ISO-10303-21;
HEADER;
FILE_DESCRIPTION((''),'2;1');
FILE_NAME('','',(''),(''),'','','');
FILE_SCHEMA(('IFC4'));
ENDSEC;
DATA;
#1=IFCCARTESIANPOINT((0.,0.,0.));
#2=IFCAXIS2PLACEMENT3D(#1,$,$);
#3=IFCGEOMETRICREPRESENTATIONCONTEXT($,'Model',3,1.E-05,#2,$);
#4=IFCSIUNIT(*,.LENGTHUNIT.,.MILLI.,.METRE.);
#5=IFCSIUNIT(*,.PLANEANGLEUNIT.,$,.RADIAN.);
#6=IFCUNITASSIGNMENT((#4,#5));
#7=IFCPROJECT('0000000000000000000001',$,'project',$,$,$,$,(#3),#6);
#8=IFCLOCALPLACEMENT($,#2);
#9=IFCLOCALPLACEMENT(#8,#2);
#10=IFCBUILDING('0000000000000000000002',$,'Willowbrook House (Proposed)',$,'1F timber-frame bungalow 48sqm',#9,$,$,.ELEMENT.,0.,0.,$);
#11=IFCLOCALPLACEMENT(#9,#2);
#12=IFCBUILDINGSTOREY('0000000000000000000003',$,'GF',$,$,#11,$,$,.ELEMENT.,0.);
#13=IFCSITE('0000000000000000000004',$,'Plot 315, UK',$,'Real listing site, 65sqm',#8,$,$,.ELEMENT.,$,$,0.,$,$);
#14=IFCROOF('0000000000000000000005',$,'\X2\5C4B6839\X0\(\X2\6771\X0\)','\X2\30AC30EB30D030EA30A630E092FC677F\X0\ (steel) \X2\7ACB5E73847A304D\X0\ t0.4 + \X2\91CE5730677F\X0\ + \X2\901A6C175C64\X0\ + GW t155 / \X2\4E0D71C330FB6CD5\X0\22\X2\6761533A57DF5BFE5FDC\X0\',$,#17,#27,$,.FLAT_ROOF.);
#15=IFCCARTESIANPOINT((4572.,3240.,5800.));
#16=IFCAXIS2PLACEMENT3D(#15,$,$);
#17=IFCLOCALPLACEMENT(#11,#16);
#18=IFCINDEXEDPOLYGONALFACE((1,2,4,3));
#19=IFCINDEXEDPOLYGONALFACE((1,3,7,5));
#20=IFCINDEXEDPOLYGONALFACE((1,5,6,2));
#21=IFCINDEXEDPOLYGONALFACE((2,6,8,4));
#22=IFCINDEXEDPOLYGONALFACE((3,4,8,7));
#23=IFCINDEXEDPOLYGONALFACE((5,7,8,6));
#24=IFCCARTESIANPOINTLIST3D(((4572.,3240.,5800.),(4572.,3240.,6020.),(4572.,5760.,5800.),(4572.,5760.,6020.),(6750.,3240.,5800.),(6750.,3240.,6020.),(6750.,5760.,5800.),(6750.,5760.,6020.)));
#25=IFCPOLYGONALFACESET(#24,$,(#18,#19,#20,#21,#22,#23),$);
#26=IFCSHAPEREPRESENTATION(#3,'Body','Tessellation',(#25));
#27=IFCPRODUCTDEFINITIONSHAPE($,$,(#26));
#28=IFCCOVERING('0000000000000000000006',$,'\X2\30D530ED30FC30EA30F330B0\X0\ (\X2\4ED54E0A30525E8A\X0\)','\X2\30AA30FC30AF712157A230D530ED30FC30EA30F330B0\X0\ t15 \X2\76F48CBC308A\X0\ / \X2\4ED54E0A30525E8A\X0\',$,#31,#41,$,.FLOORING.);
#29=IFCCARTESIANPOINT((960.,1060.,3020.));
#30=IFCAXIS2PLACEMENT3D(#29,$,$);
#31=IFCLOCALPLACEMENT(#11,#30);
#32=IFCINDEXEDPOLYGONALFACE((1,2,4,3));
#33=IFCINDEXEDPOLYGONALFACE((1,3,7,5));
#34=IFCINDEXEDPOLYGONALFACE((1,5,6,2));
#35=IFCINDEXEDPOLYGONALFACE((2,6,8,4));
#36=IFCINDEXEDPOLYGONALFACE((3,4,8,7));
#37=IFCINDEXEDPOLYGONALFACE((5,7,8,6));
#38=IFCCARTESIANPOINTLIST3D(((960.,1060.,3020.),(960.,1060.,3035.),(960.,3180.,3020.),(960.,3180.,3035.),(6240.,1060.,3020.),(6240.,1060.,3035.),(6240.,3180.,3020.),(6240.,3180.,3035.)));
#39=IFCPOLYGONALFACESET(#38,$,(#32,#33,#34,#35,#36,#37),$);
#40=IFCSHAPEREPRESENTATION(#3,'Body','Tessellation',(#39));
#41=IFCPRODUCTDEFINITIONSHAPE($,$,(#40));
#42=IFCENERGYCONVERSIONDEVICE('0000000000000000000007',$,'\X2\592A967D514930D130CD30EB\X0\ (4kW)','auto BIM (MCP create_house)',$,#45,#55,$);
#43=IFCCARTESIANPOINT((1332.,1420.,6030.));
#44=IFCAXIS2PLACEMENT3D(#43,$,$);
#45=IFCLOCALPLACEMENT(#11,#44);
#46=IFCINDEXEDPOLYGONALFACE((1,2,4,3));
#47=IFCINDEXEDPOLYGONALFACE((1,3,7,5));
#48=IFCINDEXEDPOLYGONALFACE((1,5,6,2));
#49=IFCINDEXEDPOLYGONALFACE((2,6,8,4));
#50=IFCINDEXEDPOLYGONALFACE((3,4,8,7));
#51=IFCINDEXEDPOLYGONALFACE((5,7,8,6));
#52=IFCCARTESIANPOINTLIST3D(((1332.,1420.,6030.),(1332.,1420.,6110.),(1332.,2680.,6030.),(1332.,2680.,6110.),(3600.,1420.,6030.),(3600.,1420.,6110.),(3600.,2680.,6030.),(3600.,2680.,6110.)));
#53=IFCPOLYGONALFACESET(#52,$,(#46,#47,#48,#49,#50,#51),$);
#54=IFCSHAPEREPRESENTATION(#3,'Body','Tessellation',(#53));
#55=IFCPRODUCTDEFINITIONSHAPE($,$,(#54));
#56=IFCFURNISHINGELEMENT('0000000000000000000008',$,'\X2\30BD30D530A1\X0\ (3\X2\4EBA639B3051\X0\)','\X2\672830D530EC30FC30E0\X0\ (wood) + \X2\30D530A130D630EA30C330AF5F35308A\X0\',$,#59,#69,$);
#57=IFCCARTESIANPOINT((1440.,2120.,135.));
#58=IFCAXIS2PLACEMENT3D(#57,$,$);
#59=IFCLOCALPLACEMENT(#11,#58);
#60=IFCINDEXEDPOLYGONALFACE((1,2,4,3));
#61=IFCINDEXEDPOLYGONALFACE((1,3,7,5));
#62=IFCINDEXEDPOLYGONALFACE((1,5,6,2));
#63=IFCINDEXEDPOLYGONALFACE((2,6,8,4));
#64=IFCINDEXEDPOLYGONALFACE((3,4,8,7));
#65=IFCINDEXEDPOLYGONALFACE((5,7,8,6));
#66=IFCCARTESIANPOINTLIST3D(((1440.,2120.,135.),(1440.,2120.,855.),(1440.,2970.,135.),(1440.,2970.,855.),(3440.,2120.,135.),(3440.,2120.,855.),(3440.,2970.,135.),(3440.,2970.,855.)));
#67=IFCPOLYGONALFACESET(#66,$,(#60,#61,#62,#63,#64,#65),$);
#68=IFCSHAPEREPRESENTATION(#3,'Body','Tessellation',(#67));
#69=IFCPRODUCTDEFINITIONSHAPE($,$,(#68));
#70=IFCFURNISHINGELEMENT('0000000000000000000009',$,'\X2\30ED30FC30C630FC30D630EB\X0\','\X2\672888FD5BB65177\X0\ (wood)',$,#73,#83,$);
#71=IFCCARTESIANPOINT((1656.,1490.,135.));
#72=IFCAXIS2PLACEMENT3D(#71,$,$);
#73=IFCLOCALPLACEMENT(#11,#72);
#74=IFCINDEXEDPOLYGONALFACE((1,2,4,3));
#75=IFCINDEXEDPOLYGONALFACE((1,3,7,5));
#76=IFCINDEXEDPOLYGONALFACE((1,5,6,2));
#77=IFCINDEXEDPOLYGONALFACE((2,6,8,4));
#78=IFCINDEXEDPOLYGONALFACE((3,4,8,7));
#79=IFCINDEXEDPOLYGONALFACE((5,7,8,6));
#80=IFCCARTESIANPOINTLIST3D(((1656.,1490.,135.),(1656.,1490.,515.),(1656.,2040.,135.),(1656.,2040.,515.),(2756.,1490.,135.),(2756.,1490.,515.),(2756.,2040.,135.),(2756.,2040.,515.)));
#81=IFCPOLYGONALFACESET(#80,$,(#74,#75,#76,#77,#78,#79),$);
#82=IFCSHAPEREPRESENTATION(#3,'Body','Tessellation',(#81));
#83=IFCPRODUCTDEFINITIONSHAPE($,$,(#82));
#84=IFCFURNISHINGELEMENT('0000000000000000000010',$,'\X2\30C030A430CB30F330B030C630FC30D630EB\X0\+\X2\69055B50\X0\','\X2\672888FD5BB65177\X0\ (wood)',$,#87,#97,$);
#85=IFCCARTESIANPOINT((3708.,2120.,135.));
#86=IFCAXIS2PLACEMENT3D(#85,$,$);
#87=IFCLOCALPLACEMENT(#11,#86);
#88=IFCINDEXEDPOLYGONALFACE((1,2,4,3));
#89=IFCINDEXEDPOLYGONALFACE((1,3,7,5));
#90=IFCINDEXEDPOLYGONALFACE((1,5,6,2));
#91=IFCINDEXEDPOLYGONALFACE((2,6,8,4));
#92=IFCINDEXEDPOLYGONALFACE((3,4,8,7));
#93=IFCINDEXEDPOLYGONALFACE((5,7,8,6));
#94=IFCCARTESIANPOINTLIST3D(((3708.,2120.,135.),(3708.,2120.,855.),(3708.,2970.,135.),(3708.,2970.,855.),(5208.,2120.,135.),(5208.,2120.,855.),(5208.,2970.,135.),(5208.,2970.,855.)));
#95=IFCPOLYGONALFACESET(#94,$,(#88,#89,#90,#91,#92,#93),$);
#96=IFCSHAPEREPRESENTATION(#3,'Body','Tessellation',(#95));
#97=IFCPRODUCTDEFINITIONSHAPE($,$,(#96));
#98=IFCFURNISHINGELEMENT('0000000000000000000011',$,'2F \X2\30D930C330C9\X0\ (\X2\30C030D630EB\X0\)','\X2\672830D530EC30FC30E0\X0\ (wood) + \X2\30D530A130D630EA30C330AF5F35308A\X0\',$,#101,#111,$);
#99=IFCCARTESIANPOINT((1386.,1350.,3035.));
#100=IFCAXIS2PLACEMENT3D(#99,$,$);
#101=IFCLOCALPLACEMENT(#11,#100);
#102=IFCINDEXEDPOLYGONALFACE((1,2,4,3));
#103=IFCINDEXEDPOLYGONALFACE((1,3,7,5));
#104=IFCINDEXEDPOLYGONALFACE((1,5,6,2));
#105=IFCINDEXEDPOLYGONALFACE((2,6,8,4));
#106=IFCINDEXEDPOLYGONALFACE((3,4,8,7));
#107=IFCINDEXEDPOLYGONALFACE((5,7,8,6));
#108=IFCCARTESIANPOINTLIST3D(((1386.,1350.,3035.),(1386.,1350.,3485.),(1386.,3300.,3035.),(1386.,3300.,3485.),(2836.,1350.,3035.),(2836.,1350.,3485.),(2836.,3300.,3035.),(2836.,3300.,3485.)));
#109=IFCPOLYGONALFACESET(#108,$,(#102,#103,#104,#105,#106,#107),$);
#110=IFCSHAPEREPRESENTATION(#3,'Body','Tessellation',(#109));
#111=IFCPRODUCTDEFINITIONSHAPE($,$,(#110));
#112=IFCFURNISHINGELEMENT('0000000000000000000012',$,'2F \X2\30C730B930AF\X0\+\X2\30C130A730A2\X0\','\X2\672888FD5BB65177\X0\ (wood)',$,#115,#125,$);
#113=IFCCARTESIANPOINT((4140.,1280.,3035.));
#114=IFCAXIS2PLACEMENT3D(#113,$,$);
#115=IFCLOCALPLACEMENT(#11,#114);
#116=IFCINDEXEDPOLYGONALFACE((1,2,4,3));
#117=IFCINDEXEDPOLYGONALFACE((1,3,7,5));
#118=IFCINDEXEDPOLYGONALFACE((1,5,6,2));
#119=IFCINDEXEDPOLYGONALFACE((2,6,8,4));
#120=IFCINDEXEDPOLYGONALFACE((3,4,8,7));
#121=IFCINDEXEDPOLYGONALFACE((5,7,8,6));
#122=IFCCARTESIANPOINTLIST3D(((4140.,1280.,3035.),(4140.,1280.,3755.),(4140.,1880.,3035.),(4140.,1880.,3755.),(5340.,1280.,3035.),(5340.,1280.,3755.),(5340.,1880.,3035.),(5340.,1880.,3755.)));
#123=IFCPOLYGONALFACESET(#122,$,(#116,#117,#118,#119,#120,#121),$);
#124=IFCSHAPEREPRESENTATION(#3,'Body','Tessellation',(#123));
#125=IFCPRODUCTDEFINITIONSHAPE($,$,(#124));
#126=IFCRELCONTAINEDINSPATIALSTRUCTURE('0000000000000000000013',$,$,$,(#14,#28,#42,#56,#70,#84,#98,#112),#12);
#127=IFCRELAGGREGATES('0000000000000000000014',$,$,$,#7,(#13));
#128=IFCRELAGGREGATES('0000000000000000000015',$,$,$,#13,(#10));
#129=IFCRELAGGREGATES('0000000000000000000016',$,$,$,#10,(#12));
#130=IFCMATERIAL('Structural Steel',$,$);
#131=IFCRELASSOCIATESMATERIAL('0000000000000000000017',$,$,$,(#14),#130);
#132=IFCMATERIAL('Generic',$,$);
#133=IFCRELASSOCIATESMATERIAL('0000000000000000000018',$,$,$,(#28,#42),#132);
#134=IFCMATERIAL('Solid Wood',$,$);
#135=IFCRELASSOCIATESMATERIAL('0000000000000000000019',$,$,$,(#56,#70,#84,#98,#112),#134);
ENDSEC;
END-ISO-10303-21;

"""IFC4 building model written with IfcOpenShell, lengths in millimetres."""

from ifc_helpers import new_model, si_unit, frame, frame_2d, origin, place, context, project, spatial, rectangle, extrude, material, element, save


model = new_model("IFC4")

# Units and contexts
model_context = context("Model", 3, precision=1e-05, world=origin())
ifc_project = project(units=[si_unit("LENGTHUNIT", "METRE", prefix="MILLI"), si_unit("PLANEANGLEUNIT", "RADIAN")], contexts=[model_context])

# Site, building, storey
site_placement = place(None, origin())
site = spatial("IfcSite", under=ifc_project, at=site_placement, Name="Plot 315, UK", ObjectType="Real listing site, 65sqm", CompositionType="ELEMENT", RefElevation=0.0)
building_placement = place(site_placement, origin())
building = spatial("IfcBuilding", under=site, at=building_placement, Name="Willowbrook House (Proposed)", ObjectType="1F timber-frame bungalow 48sqm", CompositionType="ELEMENT", ElevationOfRefHeight=0.0, ElevationOfTerrain=0.0)
storey_placement = place(building_placement, origin())
storey = spatial("IfcBuildingStorey", under=building, at=storey_placement, Name="GF", CompositionType="ELEMENT", Elevation=0.0)

# Shared definitions
ifc_material_1 = material(Name="Solid Wood")

# Shared definitions
ifc_material_2 = material(Name="Generic")

# Roof
ifc_material_3 = material(Name="Structural Steel")
roof_1_placement = place(storey_placement, frame((4572.0, 3240.0, 5800.0)))
element("IfcRoof", 1, at=roof_1_placement, inside=storey, material=ifc_material_3, Name="屋根(東)", Description="ガルバリウム鋼板 (steel) 立平葺き t0.4 + 野地板 + 通気層 + GW t155 / 不燃・法22条区域対応", PredefinedType="FLAT_ROOF", context=model_context, shape_type="SweptSolid", body=[
    extrude(rectangle(XDim=2178.0, YDim=2520.0, at=frame_2d((1089.0, 1260.0))), frame((4572.0, 3240.0, 5800.0)), (0.0, 0.0, 1.0), 220.0),
])

# Covering
covering_placement = place(storey_placement, frame((960.0, 1060.0, 3020.0)))
element("IfcCovering", 2, at=covering_placement, inside=storey, material=ifc_material_2, Name="フローリング (仕上げ床)", Description="オーク無垢フローリング t15 直貼り / 仕上げ床", PredefinedType="FLOORING", context=model_context, shape_type="SweptSolid", body=[
    extrude(rectangle(XDim=5280.0, YDim=2120.0, at=frame_2d((2640.0, 1060.0))), frame((960.0, 1060.0, 3020.0)), (0.0, 0.0, 1.0), 15.0),
])

# Energy conversion device
energy_conversion_device_placement = place(storey_placement, frame((1332.0, 1420.0, 6030.0)))
element("IfcEnergyConversionDevice", 3, at=energy_conversion_device_placement, inside=storey, material=ifc_material_2, Name="太陽光パネル (4kW)", Description="auto BIM (MCP create_house)", context=model_context, shape_type="SweptSolid", body=[
    extrude(rectangle(XDim=2268.0, YDim=1260.0, at=frame_2d((1134.0, 630.0))), frame((1332.0, 1420.0, 6030.0)), (0.0, 0.0, 1.0), 80.0),
])

# Furnishing elements
furnishing_1_placement = place(storey_placement, frame((1440.0, 2120.0, 135.0)))
element("IfcFurnishingElement", 4, at=furnishing_1_placement, inside=storey, material=ifc_material_1, Name="ソファ (3人掛け)", Description="木フレーム (wood) + ファブリック張り", context=model_context, shape_type="SweptSolid", body=[
    extrude(rectangle(XDim=2000.0, YDim=850.0, at=frame_2d((1000.0, 425.0))), frame((1440.0, 2120.0, 135.0)), (0.0, 0.0, 1.0), 720.0),
])
furnishing_2_placement = place(storey_placement, frame((1656.0, 1490.0, 135.0)))
element("IfcFurnishingElement", 5, at=furnishing_2_placement, inside=storey, material=ifc_material_1, Name="ローテーブル", Description="木製家具 (wood)", context=model_context, shape_type="SweptSolid", body=[
    extrude(rectangle(XDim=1100.0, YDim=550.0, at=frame_2d((550.0, 275.0))), frame((1656.0, 1490.0, 135.0)), (0.0, 0.0, 1.0), 380.0),
])
furnishing_3_placement = place(storey_placement, frame((3708.0, 2120.0, 135.0)))
element("IfcFurnishingElement", 6, at=furnishing_3_placement, inside=storey, material=ifc_material_1, Name="ダイニングテーブル+椅子", Description="木製家具 (wood)", context=model_context, shape_type="SweptSolid", body=[
    extrude(rectangle(XDim=1500.0, YDim=850.0, at=frame_2d((750.0, 425.0))), frame((3708.0, 2120.0, 135.0)), (0.0, 0.0, 1.0), 720.0),
])
furnishing_4_placement = place(storey_placement, frame((1386.0, 1350.0, 3035.0)))
element("IfcFurnishingElement", 7, at=furnishing_4_placement, inside=storey, material=ifc_material_1, Name="2F ベッド (ダブル)", Description="木フレーム (wood) + ファブリック張り", context=model_context, shape_type="SweptSolid", body=[
    extrude(rectangle(XDim=1450.0, YDim=1950.0, at=frame_2d((725.0, 975.0))), frame((1386.0, 1350.0, 3035.0)), (0.0, 0.0, 1.0), 450.0),
])
furnishing_5_placement = place(storey_placement, frame((4140.0, 1280.0, 3035.0)))
element("IfcFurnishingElement", 8, at=furnishing_5_placement, inside=storey, material=ifc_material_1, Name="2F デスク+チェア", Description="木製家具 (wood)", context=model_context, shape_type="SweptSolid", body=[
    extrude(rectangle(XDim=1200.0, YDim=600.0, at=frame_2d((600.0, 300.0))), frame((4140.0, 1280.0, 3035.0)), (0.0, 0.0, 1.0), 720.0),
])

save(model, "model.ifc")
